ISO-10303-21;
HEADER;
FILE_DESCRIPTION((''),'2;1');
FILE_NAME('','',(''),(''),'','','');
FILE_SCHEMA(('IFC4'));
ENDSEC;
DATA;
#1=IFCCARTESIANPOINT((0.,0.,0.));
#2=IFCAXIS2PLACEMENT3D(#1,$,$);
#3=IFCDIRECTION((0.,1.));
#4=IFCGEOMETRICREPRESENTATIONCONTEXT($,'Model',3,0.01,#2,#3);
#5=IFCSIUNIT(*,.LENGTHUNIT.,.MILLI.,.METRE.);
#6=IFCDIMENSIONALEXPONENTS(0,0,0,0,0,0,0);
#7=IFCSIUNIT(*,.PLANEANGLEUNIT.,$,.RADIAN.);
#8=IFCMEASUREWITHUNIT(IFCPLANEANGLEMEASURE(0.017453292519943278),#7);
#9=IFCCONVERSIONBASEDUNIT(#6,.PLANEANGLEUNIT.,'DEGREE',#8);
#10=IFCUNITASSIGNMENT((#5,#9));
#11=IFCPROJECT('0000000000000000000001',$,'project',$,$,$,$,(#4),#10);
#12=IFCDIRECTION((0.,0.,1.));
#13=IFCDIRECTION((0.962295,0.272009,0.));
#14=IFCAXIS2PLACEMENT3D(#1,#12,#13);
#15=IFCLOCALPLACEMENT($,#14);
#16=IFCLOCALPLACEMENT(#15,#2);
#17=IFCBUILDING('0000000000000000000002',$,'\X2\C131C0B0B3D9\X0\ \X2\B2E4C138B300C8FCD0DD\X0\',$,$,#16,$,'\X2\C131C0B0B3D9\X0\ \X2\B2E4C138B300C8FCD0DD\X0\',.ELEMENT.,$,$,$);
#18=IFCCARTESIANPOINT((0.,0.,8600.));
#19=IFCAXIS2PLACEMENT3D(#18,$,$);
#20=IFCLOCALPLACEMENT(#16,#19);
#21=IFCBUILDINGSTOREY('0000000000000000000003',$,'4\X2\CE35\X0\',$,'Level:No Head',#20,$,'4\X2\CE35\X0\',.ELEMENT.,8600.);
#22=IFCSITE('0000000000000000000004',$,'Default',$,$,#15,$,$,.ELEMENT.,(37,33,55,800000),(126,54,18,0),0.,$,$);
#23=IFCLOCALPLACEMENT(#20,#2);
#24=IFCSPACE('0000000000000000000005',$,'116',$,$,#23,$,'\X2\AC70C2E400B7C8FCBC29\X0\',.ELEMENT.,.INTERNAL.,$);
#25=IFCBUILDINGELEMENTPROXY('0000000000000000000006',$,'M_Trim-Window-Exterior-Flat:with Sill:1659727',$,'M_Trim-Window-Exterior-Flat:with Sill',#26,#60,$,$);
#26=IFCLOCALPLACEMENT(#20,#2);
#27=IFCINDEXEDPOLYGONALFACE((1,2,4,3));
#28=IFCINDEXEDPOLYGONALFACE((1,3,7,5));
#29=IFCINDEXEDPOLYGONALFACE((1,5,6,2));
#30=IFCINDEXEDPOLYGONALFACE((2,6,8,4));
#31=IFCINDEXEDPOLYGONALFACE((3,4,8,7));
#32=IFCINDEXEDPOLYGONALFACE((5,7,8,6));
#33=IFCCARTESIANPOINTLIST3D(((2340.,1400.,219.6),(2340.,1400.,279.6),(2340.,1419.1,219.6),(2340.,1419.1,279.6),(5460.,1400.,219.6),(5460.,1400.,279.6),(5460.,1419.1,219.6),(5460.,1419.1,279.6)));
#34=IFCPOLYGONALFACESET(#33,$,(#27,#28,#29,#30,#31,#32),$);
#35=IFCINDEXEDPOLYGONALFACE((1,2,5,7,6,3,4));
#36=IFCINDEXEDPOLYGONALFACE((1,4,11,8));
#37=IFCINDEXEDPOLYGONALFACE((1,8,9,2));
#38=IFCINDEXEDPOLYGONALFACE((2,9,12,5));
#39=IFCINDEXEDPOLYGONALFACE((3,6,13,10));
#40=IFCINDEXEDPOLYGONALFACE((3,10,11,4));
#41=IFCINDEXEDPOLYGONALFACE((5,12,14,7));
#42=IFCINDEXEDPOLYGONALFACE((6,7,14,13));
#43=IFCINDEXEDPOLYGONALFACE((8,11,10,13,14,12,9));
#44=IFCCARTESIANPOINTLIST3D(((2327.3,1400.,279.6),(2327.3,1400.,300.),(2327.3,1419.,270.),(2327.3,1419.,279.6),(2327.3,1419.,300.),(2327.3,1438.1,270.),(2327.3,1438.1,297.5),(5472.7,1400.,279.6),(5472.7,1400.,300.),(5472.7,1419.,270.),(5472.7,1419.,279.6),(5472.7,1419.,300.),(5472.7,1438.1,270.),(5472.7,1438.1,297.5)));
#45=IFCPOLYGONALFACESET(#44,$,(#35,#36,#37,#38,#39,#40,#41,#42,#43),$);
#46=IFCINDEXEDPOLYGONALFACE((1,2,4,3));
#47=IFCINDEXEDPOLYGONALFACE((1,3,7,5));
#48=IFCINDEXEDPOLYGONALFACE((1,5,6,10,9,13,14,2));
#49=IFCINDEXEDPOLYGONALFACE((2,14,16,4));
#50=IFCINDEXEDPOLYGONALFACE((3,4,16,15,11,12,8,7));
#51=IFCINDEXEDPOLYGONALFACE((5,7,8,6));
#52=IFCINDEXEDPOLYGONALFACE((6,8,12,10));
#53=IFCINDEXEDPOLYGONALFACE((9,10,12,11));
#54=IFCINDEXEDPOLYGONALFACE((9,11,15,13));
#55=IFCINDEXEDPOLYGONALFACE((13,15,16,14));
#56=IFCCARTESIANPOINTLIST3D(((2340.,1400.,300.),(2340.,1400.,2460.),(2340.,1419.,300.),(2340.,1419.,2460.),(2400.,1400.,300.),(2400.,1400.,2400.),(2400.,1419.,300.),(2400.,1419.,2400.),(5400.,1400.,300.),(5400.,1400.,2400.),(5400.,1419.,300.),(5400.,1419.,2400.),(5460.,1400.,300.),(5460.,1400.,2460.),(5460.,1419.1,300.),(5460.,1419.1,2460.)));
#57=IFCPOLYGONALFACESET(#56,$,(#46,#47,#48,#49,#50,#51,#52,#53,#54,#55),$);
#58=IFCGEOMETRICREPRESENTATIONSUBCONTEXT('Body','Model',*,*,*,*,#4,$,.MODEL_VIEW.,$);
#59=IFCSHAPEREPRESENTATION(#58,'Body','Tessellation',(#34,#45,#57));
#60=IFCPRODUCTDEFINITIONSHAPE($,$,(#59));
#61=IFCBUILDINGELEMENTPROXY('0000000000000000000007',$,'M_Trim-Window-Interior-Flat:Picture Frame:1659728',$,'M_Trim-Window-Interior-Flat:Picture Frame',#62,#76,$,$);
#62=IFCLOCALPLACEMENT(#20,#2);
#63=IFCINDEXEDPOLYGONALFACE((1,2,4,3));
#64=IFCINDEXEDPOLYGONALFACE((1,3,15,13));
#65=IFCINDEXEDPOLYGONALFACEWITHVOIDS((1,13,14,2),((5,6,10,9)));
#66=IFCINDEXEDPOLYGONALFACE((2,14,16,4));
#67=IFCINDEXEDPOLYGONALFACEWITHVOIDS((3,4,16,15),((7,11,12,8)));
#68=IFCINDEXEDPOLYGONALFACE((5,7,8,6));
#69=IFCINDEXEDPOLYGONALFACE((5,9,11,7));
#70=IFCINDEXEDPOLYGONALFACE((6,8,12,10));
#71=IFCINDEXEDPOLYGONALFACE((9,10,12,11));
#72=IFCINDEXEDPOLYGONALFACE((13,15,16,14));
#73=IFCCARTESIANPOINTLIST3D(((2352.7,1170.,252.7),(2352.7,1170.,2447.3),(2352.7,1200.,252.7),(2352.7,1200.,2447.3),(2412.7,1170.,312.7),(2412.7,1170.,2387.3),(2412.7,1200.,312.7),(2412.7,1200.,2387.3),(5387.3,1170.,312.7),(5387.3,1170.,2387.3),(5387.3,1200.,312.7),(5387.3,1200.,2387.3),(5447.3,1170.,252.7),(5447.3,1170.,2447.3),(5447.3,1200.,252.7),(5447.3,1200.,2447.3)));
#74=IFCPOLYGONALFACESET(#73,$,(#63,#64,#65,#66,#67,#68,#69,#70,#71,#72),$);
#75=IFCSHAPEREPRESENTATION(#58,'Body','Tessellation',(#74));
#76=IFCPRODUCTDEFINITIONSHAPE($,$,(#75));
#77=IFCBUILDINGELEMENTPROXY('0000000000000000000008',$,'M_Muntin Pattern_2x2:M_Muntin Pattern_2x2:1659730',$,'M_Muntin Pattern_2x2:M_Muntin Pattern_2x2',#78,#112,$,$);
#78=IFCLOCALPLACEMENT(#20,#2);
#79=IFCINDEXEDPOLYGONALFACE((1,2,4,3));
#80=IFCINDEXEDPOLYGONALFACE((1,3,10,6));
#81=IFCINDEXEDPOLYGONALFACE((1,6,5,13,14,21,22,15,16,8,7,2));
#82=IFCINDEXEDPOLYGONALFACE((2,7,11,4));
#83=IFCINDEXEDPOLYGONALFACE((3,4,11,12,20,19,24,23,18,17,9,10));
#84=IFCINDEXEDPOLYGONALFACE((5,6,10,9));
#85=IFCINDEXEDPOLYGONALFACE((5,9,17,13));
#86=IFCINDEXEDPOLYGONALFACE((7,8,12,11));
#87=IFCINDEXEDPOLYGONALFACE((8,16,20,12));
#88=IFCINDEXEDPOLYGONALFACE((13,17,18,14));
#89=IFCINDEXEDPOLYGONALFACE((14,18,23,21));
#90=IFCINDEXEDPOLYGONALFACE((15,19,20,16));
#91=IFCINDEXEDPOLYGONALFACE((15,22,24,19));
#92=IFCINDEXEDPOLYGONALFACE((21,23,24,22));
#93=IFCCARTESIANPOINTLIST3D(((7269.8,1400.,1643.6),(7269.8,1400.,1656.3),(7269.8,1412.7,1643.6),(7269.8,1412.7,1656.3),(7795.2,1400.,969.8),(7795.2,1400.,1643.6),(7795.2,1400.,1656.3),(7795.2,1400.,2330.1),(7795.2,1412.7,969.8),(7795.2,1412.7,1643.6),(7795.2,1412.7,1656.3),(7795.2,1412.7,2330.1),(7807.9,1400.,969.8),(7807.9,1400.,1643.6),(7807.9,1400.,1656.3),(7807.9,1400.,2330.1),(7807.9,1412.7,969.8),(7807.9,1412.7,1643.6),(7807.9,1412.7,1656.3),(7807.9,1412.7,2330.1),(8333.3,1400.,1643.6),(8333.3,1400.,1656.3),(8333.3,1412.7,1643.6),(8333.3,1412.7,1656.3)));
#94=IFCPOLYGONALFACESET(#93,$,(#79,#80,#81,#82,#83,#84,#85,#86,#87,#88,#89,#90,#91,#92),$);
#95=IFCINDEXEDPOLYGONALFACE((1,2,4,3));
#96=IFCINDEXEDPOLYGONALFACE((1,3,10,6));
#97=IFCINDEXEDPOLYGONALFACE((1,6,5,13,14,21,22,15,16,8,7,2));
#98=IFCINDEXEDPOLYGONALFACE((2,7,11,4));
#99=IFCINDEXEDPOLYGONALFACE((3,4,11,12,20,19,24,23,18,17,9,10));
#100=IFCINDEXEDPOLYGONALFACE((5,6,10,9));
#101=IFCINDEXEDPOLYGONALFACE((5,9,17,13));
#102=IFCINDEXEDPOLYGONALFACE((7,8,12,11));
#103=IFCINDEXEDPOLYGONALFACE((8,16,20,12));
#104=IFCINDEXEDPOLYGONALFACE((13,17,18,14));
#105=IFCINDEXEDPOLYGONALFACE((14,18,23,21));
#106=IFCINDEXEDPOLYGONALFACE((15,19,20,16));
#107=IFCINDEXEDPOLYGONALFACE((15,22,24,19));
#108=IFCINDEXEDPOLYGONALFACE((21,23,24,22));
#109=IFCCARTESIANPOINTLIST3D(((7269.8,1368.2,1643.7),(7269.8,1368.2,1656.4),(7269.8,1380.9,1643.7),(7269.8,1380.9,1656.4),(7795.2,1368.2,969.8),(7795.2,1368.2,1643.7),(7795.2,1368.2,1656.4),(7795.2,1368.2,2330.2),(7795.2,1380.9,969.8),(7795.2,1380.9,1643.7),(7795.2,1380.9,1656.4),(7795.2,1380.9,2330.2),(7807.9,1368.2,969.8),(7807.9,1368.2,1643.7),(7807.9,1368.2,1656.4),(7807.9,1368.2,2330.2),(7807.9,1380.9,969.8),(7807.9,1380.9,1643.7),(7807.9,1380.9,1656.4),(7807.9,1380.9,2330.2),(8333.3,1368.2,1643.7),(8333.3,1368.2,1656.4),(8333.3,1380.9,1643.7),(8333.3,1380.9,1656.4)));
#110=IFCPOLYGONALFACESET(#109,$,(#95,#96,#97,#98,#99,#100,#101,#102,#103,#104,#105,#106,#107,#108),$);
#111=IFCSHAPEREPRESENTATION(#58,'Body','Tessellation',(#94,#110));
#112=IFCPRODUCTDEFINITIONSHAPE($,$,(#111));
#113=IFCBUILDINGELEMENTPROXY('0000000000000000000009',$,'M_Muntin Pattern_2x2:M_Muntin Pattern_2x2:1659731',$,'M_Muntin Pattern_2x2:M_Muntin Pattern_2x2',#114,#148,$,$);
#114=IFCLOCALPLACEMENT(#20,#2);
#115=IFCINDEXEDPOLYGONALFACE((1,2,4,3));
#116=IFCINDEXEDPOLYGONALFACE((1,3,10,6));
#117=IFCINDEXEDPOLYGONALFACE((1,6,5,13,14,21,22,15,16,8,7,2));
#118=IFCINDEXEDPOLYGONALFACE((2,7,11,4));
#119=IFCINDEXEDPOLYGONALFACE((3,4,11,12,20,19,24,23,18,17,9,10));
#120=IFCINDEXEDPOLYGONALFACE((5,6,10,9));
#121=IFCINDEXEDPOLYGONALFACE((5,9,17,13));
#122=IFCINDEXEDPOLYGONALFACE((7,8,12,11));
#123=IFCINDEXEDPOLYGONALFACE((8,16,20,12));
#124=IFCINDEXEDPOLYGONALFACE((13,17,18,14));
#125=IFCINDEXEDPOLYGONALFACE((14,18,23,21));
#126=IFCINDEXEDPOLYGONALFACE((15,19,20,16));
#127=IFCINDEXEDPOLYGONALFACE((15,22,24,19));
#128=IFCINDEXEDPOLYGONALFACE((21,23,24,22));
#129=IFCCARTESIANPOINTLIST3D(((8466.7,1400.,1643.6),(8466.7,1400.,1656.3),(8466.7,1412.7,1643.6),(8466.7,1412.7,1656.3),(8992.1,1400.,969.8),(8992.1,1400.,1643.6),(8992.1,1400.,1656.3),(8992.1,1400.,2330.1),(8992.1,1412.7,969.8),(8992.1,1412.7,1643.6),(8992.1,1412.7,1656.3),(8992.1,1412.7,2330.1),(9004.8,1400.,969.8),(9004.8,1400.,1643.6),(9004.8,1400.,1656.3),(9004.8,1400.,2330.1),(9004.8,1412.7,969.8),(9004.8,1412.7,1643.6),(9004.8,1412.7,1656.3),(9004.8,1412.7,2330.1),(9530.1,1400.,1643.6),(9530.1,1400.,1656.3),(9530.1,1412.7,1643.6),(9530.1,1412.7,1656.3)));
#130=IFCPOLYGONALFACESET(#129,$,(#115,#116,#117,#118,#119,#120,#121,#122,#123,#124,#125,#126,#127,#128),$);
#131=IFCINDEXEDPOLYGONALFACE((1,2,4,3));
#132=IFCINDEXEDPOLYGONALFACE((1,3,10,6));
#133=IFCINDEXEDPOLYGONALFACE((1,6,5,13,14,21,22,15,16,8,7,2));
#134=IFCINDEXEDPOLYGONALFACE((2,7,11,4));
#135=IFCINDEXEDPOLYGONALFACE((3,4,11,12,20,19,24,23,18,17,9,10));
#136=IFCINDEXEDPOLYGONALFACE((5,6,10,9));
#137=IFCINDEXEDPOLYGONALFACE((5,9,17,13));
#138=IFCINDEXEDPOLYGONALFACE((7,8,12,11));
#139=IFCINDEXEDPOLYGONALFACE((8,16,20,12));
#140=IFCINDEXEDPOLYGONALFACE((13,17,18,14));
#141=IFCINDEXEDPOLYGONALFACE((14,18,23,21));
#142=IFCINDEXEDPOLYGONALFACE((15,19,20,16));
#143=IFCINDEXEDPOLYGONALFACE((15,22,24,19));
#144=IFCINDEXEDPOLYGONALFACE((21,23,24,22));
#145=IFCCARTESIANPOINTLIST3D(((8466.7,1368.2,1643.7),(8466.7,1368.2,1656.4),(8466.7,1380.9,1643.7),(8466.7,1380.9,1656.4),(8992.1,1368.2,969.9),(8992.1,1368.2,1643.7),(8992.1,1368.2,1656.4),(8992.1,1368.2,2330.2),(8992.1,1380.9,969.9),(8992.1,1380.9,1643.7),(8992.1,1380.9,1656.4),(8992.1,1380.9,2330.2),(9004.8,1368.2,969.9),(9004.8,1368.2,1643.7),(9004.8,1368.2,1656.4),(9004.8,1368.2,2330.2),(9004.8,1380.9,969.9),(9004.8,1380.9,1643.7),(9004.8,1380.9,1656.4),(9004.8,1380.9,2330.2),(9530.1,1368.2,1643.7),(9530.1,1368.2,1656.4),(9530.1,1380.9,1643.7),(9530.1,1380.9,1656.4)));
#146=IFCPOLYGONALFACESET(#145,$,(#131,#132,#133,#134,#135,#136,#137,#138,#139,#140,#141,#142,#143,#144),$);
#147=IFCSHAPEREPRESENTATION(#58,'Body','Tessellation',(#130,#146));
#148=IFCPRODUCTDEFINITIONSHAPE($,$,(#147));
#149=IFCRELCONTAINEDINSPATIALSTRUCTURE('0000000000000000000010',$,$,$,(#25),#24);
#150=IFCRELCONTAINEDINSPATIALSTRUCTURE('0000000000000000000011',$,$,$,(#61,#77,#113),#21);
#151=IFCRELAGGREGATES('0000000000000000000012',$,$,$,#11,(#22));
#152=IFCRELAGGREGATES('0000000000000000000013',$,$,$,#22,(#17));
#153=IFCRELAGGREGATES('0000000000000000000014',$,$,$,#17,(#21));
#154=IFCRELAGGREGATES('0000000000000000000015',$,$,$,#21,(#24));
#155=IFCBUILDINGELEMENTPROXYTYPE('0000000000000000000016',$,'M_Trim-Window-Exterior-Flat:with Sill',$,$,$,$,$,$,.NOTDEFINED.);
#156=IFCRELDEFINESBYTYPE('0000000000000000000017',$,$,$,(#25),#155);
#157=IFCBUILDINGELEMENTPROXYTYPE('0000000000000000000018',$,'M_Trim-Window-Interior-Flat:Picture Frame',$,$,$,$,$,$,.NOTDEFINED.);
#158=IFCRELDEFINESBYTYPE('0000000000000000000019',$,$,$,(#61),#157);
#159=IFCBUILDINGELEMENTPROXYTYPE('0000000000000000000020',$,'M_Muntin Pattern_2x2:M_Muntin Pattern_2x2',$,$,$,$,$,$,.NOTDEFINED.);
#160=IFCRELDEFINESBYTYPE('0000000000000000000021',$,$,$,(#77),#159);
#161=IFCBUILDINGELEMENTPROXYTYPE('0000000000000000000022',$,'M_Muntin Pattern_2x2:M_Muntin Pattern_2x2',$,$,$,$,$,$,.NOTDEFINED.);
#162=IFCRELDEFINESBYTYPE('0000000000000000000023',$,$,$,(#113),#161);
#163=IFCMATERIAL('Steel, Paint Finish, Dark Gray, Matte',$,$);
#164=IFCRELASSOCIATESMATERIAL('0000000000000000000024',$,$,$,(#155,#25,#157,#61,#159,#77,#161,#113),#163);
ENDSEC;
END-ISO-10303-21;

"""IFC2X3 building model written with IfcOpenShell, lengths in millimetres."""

from ifc_helpers import new_model, entity, si_unit, converted_unit, direction, frame, frame_2d, origin, place, context, subcontext, project, spatial, polyline, rectangle, outline, extrude, source, transform, mapped, material, type_object, type_shapes, element, save


model = new_model("IFC2X3")

# Units and contexts
model_context = context("Model", 3, precision=0.01, world=origin(), true_north=direction((0.0, 1.0)))
body_context = subcontext(model_context, "Body", "Model", "MODEL_VIEW")
ifc_project = project(units=[si_unit("LENGTHUNIT", "METRE", prefix="MILLI"), converted_unit("PLANEANGLEUNIT", "DEGREE", entity("IfcPlaneAngleMeasure", 0.017453292519943278), si_unit("PLANEANGLEUNIT", "RADIAN"), dimensions=[0, 0, 0, 0, 0, 0, 0])], contexts=[model_context])

# Site, building, storey
site_placement = place(None, frame((0.0, 0.0, 0.0), z_axis=(0.0, 0.0, 1.0), x_axis=(0.962295, 0.272009, 0.0)))
site = spatial("IfcSite", under=ifc_project, at=site_placement, Name="Default", CompositionType="ELEMENT", RefLatitude=(37, 33, 55, 800000), RefLongitude=(126, 54, 18, 0), RefElevation=0.0)
building_placement = place(site_placement, origin())
building = spatial("IfcBuilding", under=site, at=building_placement, Name="성산동 다세대주택", LongName="성산동 다세대주택", CompositionType="ELEMENT")
storey_placement = place(building_placement, frame((0.0, 0.0, 8600.0)))
storey = spatial("IfcBuildingStorey", under=building, at=storey_placement, Name="4층", ObjectType="Level:No Head", LongName="4층", CompositionType="ELEMENT", Elevation=8600.0)

# Shared definitions
ifc_material_1 = material(Name="Steel, Paint Finish, Dark Gray, Matte")

# Shared definitions
space_1_placement = place(storey_placement, origin())
space_1 = spatial("IfcSpace", under=storey, at=space_1_placement, Name="116", LongName="거실·주방", CompositionType="ELEMENT", InteriorOrExteriorSpace="INTERNAL")

# Building element proxies
building_element_proxy_type_1 = type_object("IfcBuildingElementProxyType", Name="M_Trim-Window-Exterior-Flat:with Sill", PredefinedType="NOTDEFINED", material=ifc_material_1)
shared_shape_1 = source(origin(), body_context, "Body", "SweptSolid", [
    extrude(rectangle(XDim=3120.0, YDim=60.0, at=frame_2d((0.0, 0.0), x_axis=(1.0, 0.0))), frame((0.0, -2150.4, 0.0), z_axis=(0.0, 0.0, 1.0), x_axis=(-1.0, 0.0, 0.0)), (0.0, 0.0, 1.0), 19.0),
    extrude(outline(polyline([(-19.0, -15.2), (0.0, -15.2), (0.0, -5.7), (19.0, -5.7), (19.0, 14.8), (0.0, 14.8), (-19.0, 12.3), (-19.0, -15.2)])), frame((-1572.7, -2114.8, 19.0), z_axis=(1.0, 0.0, 0.0), x_axis=(0.0, 0.0, -1.0)), (0.0, 0.0, 1.0), 3145.4),
    extrude(outline(polyline([(-1095.0, -1560.0), (1065.0, -1560.0), (1065.0, -1500.0), (-1035.0, -1500.0), (-1035.0, 1500.0), (1065.0, 1500.0), (1065.0, 1560.0), (-1095.0, 1560.0), (-1095.0, -1560.0)])), frame((0.0, -1035.0, 0.0), z_axis=(0.0, 0.0, 1.0), x_axis=(0.0, -1.0, 0.0)), (0.0, 0.0, 1.0), 19.0),
])
type_shapes(building_element_proxy_type_1, [shared_shape_1])
proxy_1_placement = place(space_1_placement, frame((3900.0, 1400.0, 2400.0), z_axis=(0.0, 1.0, 0.0), x_axis=(-1.0, 0.0, 0.0)))
element("IfcBuildingElementProxy", 1, at=proxy_1_placement, inside=space_1, type_object=building_element_proxy_type_1, material=ifc_material_1, Name="M_Trim-Window-Exterior-Flat:with Sill:1659727", ObjectType="M_Trim-Window-Exterior-Flat:with Sill", context=body_context, shape_type="MappedRepresentation", body=[
    mapped(shared_shape_1, transform((0.0, 0.0, 0.0), scale=1.0)),
])
building_element_proxy_type_2 = type_object("IfcBuildingElementProxyType", Name="M_Trim-Window-Interior-Flat:Picture Frame", PredefinedType="NOTDEFINED", material=ifc_material_1)
shared_shape_2 = source(origin(), body_context, "Body", "SweptSolid", [
    extrude(outline(polyline([(-1547.3, -1097.3), (1547.3, -1097.3), (1547.3, 1097.3), (-1547.3, 1097.3), (-1547.3, -1097.3)]), holes=[polyline([(-1487.3, -1037.3), (-1487.3, 1037.3), (1487.3, 1037.3), (1487.3, -1037.3), (-1487.3, -1037.3)])]), frame((0.0, -1050.0, 0.0), z_axis=(0.0, 0.0, 1.0), x_axis=(-1.0, 0.0, 0.0)), (0.0, 0.0, 1.0), 30.0),
])
type_shapes(building_element_proxy_type_2, [shared_shape_2])
proxy_2_placement = place(storey_placement, frame((3900.0, 1200.0, 2400.0), z_axis=(0.0, -1.0, 0.0), x_axis=(1.0, 0.0, 0.0)))
element("IfcBuildingElementProxy", 2, at=proxy_2_placement, inside=storey, type_object=building_element_proxy_type_2, material=ifc_material_1, Name="M_Trim-Window-Interior-Flat:Picture Frame:1659728", ObjectType="M_Trim-Window-Interior-Flat:Picture Frame", context=body_context, shape_type="MappedRepresentation", body=[
    mapped(shared_shape_2, transform((0.0, 0.0, 0.0), scale=1.0)),
])
building_element_proxy_type_3 = type_object("IfcBuildingElementProxyType", Name="M_Muntin Pattern_2x2:M_Muntin Pattern_2x2", PredefinedType="NOTDEFINED", material=ifc_material_1)
shared_shape_3 = source(origin(), body_context, "Body", "SweptSolid", [
    extrude(outline(polyline([(6.4, -6.4), (680.1, -6.4), (680.1, 6.3), (6.4, 6.3), (6.4, 531.7), (-6.3, 531.7), (-6.3, 6.3), (-680.2, 6.3), (-680.2, -6.4), (-6.3, -6.4), (-6.3, -531.7), (6.4, -531.7), (6.4, -6.4)])), frame((0.0, 9.5, 680.1), z_axis=(0.0, 1.0, 0.0), x_axis=(0.0, 0.0, 1.0)), (0.0, 0.0, 1.0), 12.7),
    extrude(outline(polyline([(6.4, -6.4), (680.2, -6.4), (680.2, 6.3), (6.4, 6.3), (6.4, 531.7), (-6.3, 531.7), (-6.3, 6.3), (-680.2, 6.3), (-680.2, -6.4), (-6.3, -6.4), (-6.3, -531.7), (6.4, -531.7), (6.4, -6.4)])), frame((0.0, -22.2, 680.2), z_axis=(0.0, 1.0, 0.0), x_axis=(0.0, 0.0, 1.0)), (0.0, 0.0, 1.0), 12.7),
])
type_shapes(building_element_proxy_type_3, [shared_shape_3])
proxy_3_placement = place(storey_placement, frame((7801.6, 1390.5, 969.8)))
element("IfcBuildingElementProxy", 3, at=proxy_3_placement, inside=storey, type_object=building_element_proxy_type_3, material=ifc_material_1, Name="M_Muntin Pattern_2x2:M_Muntin Pattern_2x2:1659730", ObjectType="M_Muntin Pattern_2x2:M_Muntin Pattern_2x2", context=body_context, shape_type="MappedRepresentation", body=[
    mapped(shared_shape_3, transform((0.0, 0.0, 0.0), scale=1.0)),
])
building_element_proxy_type_4 = type_object("IfcBuildingElementProxyType", Name="M_Muntin Pattern_2x2:M_Muntin Pattern_2x2", PredefinedType="NOTDEFINED", material=ifc_material_1)
shared_shape_4 = source(origin(), body_context, "Body", "SweptSolid", [
    extrude(outline(polyline([(6.4, -6.4), (680.1, -6.4), (680.1, 6.3), (6.4, 6.3), (6.4, 531.7), (-6.3, 531.7), (-6.3, 6.3), (-680.2, 6.3), (-680.2, -6.4), (-6.3, -6.4), (-6.3, -531.7), (6.4, -531.7), (6.4, -6.4)])), frame((0.0, -22.2, 680.1), z_axis=(0.0, 1.0, 0.0), x_axis=(0.0, 0.0, 1.0)), (0.0, 0.0, 1.0), 12.7),
    extrude(outline(polyline([(6.4, -6.4), (680.2, -6.4), (680.2, 6.3), (6.4, 6.3), (6.4, 531.7), (-6.3, 531.7), (-6.3, 6.3), (-680.2, 6.3), (-680.2, -6.4), (-6.3, -6.4), (-6.3, -531.7), (6.4, -531.7), (6.4, -6.4)])), frame((0.0, 9.5, 680.2), z_axis=(0.0, 1.0, 0.0), x_axis=(0.0, 0.0, 1.0)), (0.0, 0.0, 1.0), 12.7),
])
type_shapes(building_element_proxy_type_4, [shared_shape_4])
proxy_4_placement = place(storey_placement, frame((8998.4, 1390.5, 969.9), z_axis=(0.0, 0.0, 1.0), x_axis=(-1.0, 0.0, 0.0)))
element("IfcBuildingElementProxy", 4, at=proxy_4_placement, inside=storey, type_object=building_element_proxy_type_4, material=ifc_material_1, Name="M_Muntin Pattern_2x2:M_Muntin Pattern_2x2:1659731", ObjectType="M_Muntin Pattern_2x2:M_Muntin Pattern_2x2", context=body_context, shape_type="MappedRepresentation", body=[
    mapped(shared_shape_4, transform((0.0, 0.0, 0.0), scale=1.0)),
])

save(model, "model.ifc")
